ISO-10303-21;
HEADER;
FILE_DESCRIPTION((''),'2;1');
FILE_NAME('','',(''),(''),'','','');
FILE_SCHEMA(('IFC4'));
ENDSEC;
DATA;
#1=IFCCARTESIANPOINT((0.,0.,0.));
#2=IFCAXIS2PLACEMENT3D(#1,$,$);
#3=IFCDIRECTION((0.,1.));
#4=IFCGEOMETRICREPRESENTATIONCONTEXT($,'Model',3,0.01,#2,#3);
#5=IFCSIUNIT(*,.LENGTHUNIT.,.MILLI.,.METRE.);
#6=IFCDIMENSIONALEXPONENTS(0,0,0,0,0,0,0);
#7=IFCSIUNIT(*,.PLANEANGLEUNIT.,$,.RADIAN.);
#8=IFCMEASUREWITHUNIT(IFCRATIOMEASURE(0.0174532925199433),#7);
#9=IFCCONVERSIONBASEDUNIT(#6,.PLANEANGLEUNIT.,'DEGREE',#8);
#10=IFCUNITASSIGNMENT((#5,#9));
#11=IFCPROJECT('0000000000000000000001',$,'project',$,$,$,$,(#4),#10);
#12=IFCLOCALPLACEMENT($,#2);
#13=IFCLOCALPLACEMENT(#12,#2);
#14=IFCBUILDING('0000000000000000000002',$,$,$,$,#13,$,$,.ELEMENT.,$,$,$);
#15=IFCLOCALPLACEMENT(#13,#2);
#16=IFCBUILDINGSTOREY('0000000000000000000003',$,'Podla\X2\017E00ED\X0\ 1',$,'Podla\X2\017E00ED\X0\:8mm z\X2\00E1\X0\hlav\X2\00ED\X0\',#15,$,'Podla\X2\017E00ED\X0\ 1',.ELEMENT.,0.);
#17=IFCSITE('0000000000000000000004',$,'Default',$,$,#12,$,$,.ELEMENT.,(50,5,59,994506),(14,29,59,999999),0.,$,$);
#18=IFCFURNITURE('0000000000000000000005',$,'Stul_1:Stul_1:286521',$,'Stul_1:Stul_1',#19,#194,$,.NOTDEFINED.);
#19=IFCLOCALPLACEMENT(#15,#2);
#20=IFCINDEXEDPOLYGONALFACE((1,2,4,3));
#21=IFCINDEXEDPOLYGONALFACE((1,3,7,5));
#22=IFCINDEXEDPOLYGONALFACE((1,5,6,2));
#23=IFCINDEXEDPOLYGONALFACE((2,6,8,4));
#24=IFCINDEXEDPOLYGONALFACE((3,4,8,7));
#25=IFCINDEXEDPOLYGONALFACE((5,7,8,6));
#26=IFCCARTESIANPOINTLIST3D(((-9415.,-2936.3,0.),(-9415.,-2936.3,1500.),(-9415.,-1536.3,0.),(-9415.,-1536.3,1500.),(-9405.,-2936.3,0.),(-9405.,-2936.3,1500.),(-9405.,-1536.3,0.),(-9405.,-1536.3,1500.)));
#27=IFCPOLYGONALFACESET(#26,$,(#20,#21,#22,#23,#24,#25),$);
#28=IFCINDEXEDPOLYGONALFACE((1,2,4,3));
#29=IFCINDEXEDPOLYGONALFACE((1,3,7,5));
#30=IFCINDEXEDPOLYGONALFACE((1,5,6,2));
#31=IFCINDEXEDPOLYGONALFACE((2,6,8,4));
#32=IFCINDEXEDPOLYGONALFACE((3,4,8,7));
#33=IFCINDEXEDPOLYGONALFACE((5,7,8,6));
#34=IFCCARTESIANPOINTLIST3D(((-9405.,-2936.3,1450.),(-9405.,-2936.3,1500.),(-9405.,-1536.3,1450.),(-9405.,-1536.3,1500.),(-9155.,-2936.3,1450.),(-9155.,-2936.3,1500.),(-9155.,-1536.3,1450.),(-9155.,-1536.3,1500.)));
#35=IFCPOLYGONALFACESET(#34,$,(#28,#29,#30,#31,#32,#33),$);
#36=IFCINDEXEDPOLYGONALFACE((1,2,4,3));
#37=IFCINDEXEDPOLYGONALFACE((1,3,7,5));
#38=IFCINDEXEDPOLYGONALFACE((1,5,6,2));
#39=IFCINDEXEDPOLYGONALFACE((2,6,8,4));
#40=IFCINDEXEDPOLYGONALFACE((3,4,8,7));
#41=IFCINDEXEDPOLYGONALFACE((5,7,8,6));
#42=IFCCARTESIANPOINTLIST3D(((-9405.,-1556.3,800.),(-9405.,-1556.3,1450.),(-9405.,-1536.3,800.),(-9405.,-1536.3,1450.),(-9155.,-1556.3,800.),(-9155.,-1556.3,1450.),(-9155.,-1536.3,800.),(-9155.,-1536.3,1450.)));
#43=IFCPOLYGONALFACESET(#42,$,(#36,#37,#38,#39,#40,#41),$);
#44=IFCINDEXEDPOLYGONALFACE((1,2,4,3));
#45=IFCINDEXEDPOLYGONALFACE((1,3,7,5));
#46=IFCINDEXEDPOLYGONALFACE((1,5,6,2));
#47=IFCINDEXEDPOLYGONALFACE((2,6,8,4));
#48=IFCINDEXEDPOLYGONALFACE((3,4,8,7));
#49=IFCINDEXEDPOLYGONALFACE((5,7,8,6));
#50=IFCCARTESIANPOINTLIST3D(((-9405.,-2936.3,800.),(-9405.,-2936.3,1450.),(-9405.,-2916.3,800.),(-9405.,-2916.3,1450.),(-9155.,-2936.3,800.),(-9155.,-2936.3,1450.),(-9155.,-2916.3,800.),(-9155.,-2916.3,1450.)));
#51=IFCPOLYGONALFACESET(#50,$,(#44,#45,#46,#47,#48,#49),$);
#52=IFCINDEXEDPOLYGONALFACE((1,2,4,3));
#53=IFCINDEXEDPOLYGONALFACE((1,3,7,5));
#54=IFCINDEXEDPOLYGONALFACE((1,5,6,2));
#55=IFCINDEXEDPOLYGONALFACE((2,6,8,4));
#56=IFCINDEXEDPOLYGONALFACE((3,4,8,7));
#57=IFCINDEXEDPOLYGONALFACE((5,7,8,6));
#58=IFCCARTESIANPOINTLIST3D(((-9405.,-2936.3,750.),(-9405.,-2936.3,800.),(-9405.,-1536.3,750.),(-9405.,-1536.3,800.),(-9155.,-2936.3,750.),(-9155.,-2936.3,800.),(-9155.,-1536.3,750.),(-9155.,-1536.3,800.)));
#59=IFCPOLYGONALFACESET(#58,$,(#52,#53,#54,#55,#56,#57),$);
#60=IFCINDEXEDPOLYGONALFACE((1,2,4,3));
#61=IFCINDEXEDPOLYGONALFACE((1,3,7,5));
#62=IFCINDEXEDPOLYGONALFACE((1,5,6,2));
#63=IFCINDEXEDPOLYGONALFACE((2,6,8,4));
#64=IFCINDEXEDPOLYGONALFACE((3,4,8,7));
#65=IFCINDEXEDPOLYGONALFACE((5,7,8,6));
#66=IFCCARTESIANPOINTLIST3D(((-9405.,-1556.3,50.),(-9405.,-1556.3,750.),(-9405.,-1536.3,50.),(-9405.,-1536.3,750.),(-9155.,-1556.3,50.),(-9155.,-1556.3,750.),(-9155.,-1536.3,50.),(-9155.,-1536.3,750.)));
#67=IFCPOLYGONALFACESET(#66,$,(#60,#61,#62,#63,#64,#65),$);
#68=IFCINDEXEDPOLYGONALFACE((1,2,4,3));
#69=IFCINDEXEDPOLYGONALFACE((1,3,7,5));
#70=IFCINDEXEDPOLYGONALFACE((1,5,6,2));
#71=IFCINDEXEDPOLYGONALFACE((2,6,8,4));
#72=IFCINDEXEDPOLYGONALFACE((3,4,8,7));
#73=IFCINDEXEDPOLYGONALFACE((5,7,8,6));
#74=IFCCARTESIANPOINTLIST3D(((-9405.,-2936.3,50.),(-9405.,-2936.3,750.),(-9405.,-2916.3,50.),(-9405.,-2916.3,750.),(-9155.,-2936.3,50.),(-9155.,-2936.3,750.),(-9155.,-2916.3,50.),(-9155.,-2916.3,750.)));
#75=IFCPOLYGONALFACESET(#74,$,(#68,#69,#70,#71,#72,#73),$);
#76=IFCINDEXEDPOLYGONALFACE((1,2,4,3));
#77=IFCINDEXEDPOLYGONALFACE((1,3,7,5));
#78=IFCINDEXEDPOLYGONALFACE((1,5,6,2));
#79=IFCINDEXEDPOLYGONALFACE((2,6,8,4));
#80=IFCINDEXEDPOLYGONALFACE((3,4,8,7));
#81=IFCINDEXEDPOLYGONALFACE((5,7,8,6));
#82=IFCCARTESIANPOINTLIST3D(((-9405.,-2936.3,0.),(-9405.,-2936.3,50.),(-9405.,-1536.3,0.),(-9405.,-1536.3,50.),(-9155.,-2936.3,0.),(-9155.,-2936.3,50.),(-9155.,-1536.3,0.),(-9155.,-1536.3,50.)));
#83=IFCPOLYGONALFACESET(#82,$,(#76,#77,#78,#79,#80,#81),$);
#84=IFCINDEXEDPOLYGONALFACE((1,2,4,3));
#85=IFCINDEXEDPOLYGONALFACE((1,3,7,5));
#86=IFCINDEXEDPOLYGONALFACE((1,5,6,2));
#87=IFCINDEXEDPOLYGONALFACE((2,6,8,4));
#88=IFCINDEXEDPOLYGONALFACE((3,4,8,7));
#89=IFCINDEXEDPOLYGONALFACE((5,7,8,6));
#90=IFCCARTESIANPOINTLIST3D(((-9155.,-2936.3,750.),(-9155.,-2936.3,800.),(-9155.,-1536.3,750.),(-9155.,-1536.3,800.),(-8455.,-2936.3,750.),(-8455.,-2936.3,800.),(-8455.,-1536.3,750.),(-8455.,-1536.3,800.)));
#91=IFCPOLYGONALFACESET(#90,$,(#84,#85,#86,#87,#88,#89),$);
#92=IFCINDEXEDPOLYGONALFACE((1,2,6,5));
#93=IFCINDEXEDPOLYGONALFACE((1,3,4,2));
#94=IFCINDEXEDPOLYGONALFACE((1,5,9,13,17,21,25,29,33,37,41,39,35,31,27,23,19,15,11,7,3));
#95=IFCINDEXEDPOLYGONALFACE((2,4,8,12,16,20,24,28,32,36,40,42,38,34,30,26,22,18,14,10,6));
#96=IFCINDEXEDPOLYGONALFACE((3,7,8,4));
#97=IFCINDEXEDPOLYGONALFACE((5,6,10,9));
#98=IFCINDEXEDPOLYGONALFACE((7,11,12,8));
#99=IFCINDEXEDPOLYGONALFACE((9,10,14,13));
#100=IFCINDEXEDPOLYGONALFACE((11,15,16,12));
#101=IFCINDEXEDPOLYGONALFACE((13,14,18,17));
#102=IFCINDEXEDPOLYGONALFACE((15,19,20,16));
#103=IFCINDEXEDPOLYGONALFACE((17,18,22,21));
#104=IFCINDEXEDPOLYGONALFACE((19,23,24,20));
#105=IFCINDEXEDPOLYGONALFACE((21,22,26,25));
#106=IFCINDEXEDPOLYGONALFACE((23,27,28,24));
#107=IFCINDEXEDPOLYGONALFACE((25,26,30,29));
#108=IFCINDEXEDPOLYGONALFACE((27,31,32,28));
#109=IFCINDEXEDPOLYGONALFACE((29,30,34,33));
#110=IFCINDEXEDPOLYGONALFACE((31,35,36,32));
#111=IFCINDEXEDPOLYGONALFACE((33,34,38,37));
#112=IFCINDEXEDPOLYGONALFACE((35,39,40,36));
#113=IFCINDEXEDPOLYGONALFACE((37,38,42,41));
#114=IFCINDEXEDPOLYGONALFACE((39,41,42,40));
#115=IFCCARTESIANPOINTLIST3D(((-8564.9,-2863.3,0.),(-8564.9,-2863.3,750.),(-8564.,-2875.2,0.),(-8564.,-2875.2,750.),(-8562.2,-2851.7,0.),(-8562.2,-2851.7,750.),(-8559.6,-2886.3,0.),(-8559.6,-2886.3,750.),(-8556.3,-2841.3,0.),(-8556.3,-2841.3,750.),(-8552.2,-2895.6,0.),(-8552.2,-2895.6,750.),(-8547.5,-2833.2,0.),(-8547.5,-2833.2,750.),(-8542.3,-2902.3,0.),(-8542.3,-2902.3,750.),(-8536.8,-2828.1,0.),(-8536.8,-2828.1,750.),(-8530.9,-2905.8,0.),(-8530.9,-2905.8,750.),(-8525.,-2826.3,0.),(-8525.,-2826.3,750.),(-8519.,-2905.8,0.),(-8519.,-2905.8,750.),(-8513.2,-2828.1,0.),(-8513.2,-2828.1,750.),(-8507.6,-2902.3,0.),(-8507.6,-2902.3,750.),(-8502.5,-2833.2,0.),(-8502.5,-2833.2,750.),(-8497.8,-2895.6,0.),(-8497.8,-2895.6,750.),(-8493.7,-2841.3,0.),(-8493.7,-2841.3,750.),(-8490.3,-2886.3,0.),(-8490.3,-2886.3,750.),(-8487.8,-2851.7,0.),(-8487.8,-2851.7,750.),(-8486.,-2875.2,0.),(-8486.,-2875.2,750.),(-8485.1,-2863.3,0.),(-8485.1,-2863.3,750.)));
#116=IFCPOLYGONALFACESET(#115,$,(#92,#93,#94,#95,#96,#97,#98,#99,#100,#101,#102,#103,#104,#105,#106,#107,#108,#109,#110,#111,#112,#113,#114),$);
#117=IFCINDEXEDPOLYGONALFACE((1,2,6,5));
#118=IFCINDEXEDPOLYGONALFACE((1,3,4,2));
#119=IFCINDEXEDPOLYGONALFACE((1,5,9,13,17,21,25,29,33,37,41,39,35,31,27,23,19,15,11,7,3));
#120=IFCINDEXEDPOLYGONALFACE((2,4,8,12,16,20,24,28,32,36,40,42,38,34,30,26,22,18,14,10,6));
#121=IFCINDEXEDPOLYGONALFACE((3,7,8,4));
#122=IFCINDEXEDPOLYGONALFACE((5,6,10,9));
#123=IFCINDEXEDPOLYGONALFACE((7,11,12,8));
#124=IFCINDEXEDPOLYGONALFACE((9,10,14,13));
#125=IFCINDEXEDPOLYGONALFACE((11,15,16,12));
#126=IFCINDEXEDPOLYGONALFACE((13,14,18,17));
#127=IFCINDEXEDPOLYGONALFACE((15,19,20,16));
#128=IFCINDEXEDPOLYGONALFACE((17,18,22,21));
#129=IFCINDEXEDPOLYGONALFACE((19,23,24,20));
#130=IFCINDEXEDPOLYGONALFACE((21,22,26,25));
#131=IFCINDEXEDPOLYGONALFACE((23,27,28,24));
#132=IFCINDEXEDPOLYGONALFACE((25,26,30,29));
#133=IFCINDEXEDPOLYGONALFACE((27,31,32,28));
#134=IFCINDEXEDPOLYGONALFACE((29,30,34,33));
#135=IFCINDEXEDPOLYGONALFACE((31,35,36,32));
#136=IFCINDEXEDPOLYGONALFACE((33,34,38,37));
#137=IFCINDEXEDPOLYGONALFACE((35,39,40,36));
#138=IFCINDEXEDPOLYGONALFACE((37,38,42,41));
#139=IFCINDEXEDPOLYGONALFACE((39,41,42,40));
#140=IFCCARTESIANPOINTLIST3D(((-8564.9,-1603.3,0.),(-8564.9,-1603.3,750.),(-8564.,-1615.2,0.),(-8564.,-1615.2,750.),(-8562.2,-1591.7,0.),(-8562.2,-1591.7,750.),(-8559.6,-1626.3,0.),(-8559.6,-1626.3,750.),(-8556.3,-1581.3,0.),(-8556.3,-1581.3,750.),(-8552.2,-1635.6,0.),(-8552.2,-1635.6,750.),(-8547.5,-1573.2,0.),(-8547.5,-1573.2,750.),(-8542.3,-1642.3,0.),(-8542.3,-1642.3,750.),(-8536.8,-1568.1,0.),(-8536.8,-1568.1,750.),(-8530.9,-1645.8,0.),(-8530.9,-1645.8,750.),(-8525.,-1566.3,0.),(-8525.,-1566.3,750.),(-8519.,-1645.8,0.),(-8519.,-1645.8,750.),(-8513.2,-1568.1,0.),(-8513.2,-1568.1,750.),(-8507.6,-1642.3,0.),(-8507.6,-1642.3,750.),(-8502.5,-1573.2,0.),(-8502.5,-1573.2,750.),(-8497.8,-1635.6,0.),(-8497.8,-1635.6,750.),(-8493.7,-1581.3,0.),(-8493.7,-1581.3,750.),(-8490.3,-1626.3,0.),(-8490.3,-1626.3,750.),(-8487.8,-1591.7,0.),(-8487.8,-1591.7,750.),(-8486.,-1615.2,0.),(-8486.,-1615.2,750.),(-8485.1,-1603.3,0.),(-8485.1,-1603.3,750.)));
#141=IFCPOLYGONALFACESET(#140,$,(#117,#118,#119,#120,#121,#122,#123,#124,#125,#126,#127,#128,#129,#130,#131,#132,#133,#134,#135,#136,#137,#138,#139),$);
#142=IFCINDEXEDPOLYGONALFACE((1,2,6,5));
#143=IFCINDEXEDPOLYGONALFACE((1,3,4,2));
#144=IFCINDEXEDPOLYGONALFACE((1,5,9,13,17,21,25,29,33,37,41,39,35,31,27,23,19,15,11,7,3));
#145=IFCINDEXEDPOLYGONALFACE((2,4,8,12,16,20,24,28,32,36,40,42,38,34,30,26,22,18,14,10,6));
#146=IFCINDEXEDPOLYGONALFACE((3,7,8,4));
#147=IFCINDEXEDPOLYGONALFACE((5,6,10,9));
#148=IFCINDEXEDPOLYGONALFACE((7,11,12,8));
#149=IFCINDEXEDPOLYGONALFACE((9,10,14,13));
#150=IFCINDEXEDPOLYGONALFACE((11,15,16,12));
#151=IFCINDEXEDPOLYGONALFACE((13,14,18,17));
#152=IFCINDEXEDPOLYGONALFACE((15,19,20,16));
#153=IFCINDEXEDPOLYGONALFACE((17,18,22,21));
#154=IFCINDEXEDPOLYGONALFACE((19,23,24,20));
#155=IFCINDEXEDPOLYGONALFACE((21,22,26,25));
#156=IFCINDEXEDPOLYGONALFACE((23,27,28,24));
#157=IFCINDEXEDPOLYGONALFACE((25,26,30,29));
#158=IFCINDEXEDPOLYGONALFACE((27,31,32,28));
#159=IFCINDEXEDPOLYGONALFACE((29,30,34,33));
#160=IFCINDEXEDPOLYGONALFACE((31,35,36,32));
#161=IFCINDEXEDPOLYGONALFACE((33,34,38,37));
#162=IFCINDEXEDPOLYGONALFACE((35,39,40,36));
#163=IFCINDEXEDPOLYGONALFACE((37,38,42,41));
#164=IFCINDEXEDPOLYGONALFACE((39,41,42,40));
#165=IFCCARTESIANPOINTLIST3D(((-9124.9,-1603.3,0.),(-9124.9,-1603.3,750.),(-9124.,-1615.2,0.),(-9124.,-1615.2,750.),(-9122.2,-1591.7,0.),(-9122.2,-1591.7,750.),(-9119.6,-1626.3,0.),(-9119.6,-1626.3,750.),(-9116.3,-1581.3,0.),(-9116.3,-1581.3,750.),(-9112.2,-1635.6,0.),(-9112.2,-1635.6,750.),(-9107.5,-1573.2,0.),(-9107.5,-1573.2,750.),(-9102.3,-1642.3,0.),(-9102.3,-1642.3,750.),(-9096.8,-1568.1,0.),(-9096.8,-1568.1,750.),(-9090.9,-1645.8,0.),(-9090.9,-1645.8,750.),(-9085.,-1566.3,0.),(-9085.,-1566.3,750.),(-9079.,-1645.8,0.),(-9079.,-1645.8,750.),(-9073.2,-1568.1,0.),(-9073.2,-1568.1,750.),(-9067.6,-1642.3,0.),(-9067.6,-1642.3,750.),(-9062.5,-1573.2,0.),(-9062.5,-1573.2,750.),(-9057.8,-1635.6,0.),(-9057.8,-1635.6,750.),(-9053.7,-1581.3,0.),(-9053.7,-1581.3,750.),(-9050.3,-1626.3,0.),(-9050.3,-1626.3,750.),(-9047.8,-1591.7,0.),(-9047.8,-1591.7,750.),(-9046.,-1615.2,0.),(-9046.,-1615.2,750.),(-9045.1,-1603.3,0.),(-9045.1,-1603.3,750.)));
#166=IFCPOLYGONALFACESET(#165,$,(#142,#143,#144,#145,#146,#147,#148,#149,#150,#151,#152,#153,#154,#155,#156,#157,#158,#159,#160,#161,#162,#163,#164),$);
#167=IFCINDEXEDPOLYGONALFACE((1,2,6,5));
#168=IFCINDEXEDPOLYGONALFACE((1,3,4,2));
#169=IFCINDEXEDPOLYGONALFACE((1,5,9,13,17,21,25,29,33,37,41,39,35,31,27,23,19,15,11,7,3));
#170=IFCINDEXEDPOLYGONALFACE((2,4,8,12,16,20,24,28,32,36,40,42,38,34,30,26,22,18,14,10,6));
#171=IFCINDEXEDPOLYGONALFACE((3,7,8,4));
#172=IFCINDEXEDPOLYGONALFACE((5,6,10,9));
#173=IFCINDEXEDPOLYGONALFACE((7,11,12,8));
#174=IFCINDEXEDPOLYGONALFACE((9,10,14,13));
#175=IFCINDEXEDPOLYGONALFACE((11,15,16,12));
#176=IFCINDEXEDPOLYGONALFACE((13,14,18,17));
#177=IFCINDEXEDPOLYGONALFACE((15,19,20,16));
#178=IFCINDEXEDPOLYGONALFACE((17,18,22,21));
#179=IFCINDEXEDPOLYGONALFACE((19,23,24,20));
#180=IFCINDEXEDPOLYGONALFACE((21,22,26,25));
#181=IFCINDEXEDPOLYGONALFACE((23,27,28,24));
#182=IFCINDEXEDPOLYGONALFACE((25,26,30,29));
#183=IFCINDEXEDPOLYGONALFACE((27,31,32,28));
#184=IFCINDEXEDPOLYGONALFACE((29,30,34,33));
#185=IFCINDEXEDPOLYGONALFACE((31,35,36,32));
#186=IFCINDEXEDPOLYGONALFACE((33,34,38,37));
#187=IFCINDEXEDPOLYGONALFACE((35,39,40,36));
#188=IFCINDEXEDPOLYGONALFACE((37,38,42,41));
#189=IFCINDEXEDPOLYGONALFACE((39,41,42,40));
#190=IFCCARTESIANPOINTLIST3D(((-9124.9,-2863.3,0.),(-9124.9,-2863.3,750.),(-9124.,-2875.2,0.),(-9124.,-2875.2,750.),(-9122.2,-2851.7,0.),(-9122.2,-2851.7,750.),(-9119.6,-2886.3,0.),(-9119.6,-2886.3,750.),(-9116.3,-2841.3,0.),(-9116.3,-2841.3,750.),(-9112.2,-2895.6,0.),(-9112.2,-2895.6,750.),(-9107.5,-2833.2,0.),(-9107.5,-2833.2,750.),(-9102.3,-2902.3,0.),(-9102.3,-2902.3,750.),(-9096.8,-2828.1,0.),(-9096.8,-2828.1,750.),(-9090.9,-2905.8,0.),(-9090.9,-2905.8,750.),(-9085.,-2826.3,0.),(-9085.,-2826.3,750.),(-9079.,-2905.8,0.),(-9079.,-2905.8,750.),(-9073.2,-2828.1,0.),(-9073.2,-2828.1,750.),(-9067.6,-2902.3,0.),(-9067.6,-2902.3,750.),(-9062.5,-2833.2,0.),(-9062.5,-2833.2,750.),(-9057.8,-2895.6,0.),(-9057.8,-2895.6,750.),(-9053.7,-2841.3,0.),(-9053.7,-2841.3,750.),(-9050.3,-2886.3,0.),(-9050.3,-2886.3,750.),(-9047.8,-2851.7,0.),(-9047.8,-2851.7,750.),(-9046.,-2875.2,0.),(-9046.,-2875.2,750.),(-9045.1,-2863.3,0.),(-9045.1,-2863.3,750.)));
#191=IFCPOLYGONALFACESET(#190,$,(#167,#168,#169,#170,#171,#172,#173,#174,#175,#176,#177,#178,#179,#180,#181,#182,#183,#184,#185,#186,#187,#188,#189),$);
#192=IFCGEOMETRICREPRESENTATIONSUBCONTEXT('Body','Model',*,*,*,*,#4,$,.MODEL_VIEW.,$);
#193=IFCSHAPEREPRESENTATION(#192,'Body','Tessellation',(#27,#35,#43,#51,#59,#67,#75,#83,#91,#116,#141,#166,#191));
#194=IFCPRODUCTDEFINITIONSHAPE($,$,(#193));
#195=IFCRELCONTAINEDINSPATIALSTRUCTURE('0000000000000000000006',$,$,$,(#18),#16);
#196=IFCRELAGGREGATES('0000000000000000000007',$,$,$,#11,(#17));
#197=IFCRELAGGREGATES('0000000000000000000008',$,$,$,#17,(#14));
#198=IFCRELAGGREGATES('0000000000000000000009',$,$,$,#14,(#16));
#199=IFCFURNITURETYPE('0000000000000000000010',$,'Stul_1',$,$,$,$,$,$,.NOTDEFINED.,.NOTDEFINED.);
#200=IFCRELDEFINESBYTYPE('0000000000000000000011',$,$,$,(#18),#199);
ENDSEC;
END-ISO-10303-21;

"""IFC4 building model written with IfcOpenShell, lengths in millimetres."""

from ifc_helpers import new_model, entity, si_unit, converted_unit, direction, frame, frame_2d, origin, origin_2d_with_axis, place, context, subcontext, project, spatial, rectangle, circle, extrude, source, transform, mapped, type_object, type_shapes, element, save


model = new_model("IFC4")

# Units and contexts
model_context = context("Model", 3, precision=0.01, world=origin(), true_north=direction((0.0, 1.0)))
body_context = subcontext(model_context, "Body", "Model", "MODEL_VIEW")
ifc_project = project(units=[si_unit("LENGTHUNIT", "METRE", prefix="MILLI"), converted_unit("PLANEANGLEUNIT", "DEGREE", entity("IfcRatioMeasure", 0.0174532925199433), si_unit("PLANEANGLEUNIT", "RADIAN"), dimensions=[0, 0, 0, 0, 0, 0, 0])], contexts=[model_context])

# Site, building, storey
site_placement = place(None, origin())
site = spatial("IfcSite", under=ifc_project, at=site_placement, Name="Default", CompositionType="ELEMENT", RefLatitude=(50, 5, 59, 994506), RefLongitude=(14, 29, 59, 999999), RefElevation=0.0)
building_placement = place(site_placement, origin())
building = spatial("IfcBuilding", under=site, at=building_placement, CompositionType="ELEMENT")
storey_placement = place(building_placement, origin())
storey = spatial("IfcBuildingStorey", under=building, at=storey_placement, Name="Podlaží 1", ObjectType="Podlaží:8mm záhlaví", LongName="Podlaží 1", CompositionType="ELEMENT", Elevation=0.0)

# Furniture
furniture_type = type_object("IfcFurnitureType", Name="Stul_1", AssemblyPlace="NOTDEFINED", PredefinedType="NOTDEFINED")
shared_shape_1 = source(origin(), body_context, "Body", "SweptSolid", [
    extrude(rectangle(XDim=1400.0, YDim=10.0, at=origin_2d_with_axis()), frame((0.0, 605.0, 0.0), z_axis=(0.0, 0.0, 1.0), x_axis=(-1.0, 0.0, 0.0)), (0.0, 0.0, 1.0), 1500.0),
    extrude(rectangle(XDim=1400.0, YDim=250.0, at=frame_2d((0.0, 0.0), x_axis=(1.0, 0.0))), frame((0.0, 475.0, 1450.0), z_axis=(0.0, 0.0, 1.0), x_axis=(-1.0, 0.0, 0.0)), (0.0, 0.0, 1.0), 50.0),
    extrude(rectangle(XDim=20.0, YDim=250.0, at=origin_2d_with_axis()), frame((690.0, 475.0, 800.0), z_axis=(0.0, 0.0, 1.0), x_axis=(-1.0, 0.0, 0.0)), (0.0, 0.0, 1.0), 650.0),
    extrude(rectangle(XDim=20.0, YDim=250.0, at=frame_2d((0.0, 0.0), x_axis=(1.0, 0.0))), frame((-690.0, 475.0, 800.0), z_axis=(0.0, 0.0, 1.0), x_axis=(-1.0, 0.0, 0.0)), (0.0, 0.0, 1.0), 650.0),
    extrude(rectangle(XDim=1400.0, YDim=250.0, at=origin_2d_with_axis()), frame((0.0, 475.0, 750.0), z_axis=(0.0, 0.0, 1.0), x_axis=(-1.0, 0.0, 0.0)), (0.0, 0.0, 1.0), 50.0),
    extrude(rectangle(XDim=20.0, YDim=250.0, at=origin_2d_with_axis()), frame((690.0, 475.0, 50.0), z_axis=(0.0, 0.0, 1.0), x_axis=(-1.0, 0.0, 0.0)), (0.0, 0.0, 1.0), 700.0),
    extrude(rectangle(XDim=20.0, YDim=250.0, at=frame_2d((0.0, 0.0), x_axis=(1.0, 0.0))), frame((-690.0, 475.0, 50.0), z_axis=(0.0, 0.0, 1.0), x_axis=(-1.0, 0.0, 0.0)), (0.0, 0.0, 1.0), 700.0),
    extrude(rectangle(XDim=1400.0, YDim=250.0, at=origin_2d_with_axis()), frame((0.0, 475.0, 0.0), z_axis=(0.0, 0.0, 1.0), x_axis=(-1.0, 0.0, 0.0)), (0.0, 0.0, 1.0), 50.0),
    extrude(rectangle(XDim=1400.0, YDim=700.0, at=origin_2d_with_axis()), frame((0.0, 0.0, 750.0), z_axis=(0.0, 0.0, 1.0), x_axis=(-1.0, 0.0, 0.0)), (0.0, 0.0, 1.0), 50.0),
    extrude(circle(Radius=40.0, at=frame_2d((0.0, 0.0), x_axis=(1.0, 0.0))), frame((-630.0, -280.0, 0.0)), (0.0, 0.0, 1.0), 750.0),
    extrude(circle(Radius=40.0, at=frame_2d((0.0, 0.0), x_axis=(1.0, 0.0))), frame((630.0, -280.0, 0.0)), (0.0, 0.0, 1.0), 750.0),
    extrude(circle(Radius=40.0, at=frame_2d((0.0, 0.0), x_axis=(1.0, 0.0))), frame((630.0, 280.0, 0.0)), (0.0, 0.0, 1.0), 750.0),
    extrude(circle(Radius=40.0, at=frame_2d((0.0, 0.0), x_axis=(1.0, 0.0))), frame((-630.0, 280.0, 0.0)), (0.0, 0.0, 1.0), 750.0),
])
type_shapes(furniture_type, [shared_shape_1])
for number, where, z_axis, x_axis, name in (
    (1, (-8805.0, -2236.3, 0.0), (0.0, 0.0, 1.0), (0.0, 1.0, 0.0), "Stul_1:Stul_1:286521"),
):
    element("IfcFurniture", number, at=place(storey_placement, frame(where, z_axis=z_axis, x_axis=x_axis)), inside=storey, type_object=furniture_type, Name=name, ObjectType="Stul_1:Stul_1", PredefinedType="NOTDEFINED", context=body_context, shape_type="MappedRepresentation", body=[
        mapped(shared_shape_1, transform((0.0, 0.0, 0.0), scale=1.0)),
    ])

save(model, "model.ifc")
